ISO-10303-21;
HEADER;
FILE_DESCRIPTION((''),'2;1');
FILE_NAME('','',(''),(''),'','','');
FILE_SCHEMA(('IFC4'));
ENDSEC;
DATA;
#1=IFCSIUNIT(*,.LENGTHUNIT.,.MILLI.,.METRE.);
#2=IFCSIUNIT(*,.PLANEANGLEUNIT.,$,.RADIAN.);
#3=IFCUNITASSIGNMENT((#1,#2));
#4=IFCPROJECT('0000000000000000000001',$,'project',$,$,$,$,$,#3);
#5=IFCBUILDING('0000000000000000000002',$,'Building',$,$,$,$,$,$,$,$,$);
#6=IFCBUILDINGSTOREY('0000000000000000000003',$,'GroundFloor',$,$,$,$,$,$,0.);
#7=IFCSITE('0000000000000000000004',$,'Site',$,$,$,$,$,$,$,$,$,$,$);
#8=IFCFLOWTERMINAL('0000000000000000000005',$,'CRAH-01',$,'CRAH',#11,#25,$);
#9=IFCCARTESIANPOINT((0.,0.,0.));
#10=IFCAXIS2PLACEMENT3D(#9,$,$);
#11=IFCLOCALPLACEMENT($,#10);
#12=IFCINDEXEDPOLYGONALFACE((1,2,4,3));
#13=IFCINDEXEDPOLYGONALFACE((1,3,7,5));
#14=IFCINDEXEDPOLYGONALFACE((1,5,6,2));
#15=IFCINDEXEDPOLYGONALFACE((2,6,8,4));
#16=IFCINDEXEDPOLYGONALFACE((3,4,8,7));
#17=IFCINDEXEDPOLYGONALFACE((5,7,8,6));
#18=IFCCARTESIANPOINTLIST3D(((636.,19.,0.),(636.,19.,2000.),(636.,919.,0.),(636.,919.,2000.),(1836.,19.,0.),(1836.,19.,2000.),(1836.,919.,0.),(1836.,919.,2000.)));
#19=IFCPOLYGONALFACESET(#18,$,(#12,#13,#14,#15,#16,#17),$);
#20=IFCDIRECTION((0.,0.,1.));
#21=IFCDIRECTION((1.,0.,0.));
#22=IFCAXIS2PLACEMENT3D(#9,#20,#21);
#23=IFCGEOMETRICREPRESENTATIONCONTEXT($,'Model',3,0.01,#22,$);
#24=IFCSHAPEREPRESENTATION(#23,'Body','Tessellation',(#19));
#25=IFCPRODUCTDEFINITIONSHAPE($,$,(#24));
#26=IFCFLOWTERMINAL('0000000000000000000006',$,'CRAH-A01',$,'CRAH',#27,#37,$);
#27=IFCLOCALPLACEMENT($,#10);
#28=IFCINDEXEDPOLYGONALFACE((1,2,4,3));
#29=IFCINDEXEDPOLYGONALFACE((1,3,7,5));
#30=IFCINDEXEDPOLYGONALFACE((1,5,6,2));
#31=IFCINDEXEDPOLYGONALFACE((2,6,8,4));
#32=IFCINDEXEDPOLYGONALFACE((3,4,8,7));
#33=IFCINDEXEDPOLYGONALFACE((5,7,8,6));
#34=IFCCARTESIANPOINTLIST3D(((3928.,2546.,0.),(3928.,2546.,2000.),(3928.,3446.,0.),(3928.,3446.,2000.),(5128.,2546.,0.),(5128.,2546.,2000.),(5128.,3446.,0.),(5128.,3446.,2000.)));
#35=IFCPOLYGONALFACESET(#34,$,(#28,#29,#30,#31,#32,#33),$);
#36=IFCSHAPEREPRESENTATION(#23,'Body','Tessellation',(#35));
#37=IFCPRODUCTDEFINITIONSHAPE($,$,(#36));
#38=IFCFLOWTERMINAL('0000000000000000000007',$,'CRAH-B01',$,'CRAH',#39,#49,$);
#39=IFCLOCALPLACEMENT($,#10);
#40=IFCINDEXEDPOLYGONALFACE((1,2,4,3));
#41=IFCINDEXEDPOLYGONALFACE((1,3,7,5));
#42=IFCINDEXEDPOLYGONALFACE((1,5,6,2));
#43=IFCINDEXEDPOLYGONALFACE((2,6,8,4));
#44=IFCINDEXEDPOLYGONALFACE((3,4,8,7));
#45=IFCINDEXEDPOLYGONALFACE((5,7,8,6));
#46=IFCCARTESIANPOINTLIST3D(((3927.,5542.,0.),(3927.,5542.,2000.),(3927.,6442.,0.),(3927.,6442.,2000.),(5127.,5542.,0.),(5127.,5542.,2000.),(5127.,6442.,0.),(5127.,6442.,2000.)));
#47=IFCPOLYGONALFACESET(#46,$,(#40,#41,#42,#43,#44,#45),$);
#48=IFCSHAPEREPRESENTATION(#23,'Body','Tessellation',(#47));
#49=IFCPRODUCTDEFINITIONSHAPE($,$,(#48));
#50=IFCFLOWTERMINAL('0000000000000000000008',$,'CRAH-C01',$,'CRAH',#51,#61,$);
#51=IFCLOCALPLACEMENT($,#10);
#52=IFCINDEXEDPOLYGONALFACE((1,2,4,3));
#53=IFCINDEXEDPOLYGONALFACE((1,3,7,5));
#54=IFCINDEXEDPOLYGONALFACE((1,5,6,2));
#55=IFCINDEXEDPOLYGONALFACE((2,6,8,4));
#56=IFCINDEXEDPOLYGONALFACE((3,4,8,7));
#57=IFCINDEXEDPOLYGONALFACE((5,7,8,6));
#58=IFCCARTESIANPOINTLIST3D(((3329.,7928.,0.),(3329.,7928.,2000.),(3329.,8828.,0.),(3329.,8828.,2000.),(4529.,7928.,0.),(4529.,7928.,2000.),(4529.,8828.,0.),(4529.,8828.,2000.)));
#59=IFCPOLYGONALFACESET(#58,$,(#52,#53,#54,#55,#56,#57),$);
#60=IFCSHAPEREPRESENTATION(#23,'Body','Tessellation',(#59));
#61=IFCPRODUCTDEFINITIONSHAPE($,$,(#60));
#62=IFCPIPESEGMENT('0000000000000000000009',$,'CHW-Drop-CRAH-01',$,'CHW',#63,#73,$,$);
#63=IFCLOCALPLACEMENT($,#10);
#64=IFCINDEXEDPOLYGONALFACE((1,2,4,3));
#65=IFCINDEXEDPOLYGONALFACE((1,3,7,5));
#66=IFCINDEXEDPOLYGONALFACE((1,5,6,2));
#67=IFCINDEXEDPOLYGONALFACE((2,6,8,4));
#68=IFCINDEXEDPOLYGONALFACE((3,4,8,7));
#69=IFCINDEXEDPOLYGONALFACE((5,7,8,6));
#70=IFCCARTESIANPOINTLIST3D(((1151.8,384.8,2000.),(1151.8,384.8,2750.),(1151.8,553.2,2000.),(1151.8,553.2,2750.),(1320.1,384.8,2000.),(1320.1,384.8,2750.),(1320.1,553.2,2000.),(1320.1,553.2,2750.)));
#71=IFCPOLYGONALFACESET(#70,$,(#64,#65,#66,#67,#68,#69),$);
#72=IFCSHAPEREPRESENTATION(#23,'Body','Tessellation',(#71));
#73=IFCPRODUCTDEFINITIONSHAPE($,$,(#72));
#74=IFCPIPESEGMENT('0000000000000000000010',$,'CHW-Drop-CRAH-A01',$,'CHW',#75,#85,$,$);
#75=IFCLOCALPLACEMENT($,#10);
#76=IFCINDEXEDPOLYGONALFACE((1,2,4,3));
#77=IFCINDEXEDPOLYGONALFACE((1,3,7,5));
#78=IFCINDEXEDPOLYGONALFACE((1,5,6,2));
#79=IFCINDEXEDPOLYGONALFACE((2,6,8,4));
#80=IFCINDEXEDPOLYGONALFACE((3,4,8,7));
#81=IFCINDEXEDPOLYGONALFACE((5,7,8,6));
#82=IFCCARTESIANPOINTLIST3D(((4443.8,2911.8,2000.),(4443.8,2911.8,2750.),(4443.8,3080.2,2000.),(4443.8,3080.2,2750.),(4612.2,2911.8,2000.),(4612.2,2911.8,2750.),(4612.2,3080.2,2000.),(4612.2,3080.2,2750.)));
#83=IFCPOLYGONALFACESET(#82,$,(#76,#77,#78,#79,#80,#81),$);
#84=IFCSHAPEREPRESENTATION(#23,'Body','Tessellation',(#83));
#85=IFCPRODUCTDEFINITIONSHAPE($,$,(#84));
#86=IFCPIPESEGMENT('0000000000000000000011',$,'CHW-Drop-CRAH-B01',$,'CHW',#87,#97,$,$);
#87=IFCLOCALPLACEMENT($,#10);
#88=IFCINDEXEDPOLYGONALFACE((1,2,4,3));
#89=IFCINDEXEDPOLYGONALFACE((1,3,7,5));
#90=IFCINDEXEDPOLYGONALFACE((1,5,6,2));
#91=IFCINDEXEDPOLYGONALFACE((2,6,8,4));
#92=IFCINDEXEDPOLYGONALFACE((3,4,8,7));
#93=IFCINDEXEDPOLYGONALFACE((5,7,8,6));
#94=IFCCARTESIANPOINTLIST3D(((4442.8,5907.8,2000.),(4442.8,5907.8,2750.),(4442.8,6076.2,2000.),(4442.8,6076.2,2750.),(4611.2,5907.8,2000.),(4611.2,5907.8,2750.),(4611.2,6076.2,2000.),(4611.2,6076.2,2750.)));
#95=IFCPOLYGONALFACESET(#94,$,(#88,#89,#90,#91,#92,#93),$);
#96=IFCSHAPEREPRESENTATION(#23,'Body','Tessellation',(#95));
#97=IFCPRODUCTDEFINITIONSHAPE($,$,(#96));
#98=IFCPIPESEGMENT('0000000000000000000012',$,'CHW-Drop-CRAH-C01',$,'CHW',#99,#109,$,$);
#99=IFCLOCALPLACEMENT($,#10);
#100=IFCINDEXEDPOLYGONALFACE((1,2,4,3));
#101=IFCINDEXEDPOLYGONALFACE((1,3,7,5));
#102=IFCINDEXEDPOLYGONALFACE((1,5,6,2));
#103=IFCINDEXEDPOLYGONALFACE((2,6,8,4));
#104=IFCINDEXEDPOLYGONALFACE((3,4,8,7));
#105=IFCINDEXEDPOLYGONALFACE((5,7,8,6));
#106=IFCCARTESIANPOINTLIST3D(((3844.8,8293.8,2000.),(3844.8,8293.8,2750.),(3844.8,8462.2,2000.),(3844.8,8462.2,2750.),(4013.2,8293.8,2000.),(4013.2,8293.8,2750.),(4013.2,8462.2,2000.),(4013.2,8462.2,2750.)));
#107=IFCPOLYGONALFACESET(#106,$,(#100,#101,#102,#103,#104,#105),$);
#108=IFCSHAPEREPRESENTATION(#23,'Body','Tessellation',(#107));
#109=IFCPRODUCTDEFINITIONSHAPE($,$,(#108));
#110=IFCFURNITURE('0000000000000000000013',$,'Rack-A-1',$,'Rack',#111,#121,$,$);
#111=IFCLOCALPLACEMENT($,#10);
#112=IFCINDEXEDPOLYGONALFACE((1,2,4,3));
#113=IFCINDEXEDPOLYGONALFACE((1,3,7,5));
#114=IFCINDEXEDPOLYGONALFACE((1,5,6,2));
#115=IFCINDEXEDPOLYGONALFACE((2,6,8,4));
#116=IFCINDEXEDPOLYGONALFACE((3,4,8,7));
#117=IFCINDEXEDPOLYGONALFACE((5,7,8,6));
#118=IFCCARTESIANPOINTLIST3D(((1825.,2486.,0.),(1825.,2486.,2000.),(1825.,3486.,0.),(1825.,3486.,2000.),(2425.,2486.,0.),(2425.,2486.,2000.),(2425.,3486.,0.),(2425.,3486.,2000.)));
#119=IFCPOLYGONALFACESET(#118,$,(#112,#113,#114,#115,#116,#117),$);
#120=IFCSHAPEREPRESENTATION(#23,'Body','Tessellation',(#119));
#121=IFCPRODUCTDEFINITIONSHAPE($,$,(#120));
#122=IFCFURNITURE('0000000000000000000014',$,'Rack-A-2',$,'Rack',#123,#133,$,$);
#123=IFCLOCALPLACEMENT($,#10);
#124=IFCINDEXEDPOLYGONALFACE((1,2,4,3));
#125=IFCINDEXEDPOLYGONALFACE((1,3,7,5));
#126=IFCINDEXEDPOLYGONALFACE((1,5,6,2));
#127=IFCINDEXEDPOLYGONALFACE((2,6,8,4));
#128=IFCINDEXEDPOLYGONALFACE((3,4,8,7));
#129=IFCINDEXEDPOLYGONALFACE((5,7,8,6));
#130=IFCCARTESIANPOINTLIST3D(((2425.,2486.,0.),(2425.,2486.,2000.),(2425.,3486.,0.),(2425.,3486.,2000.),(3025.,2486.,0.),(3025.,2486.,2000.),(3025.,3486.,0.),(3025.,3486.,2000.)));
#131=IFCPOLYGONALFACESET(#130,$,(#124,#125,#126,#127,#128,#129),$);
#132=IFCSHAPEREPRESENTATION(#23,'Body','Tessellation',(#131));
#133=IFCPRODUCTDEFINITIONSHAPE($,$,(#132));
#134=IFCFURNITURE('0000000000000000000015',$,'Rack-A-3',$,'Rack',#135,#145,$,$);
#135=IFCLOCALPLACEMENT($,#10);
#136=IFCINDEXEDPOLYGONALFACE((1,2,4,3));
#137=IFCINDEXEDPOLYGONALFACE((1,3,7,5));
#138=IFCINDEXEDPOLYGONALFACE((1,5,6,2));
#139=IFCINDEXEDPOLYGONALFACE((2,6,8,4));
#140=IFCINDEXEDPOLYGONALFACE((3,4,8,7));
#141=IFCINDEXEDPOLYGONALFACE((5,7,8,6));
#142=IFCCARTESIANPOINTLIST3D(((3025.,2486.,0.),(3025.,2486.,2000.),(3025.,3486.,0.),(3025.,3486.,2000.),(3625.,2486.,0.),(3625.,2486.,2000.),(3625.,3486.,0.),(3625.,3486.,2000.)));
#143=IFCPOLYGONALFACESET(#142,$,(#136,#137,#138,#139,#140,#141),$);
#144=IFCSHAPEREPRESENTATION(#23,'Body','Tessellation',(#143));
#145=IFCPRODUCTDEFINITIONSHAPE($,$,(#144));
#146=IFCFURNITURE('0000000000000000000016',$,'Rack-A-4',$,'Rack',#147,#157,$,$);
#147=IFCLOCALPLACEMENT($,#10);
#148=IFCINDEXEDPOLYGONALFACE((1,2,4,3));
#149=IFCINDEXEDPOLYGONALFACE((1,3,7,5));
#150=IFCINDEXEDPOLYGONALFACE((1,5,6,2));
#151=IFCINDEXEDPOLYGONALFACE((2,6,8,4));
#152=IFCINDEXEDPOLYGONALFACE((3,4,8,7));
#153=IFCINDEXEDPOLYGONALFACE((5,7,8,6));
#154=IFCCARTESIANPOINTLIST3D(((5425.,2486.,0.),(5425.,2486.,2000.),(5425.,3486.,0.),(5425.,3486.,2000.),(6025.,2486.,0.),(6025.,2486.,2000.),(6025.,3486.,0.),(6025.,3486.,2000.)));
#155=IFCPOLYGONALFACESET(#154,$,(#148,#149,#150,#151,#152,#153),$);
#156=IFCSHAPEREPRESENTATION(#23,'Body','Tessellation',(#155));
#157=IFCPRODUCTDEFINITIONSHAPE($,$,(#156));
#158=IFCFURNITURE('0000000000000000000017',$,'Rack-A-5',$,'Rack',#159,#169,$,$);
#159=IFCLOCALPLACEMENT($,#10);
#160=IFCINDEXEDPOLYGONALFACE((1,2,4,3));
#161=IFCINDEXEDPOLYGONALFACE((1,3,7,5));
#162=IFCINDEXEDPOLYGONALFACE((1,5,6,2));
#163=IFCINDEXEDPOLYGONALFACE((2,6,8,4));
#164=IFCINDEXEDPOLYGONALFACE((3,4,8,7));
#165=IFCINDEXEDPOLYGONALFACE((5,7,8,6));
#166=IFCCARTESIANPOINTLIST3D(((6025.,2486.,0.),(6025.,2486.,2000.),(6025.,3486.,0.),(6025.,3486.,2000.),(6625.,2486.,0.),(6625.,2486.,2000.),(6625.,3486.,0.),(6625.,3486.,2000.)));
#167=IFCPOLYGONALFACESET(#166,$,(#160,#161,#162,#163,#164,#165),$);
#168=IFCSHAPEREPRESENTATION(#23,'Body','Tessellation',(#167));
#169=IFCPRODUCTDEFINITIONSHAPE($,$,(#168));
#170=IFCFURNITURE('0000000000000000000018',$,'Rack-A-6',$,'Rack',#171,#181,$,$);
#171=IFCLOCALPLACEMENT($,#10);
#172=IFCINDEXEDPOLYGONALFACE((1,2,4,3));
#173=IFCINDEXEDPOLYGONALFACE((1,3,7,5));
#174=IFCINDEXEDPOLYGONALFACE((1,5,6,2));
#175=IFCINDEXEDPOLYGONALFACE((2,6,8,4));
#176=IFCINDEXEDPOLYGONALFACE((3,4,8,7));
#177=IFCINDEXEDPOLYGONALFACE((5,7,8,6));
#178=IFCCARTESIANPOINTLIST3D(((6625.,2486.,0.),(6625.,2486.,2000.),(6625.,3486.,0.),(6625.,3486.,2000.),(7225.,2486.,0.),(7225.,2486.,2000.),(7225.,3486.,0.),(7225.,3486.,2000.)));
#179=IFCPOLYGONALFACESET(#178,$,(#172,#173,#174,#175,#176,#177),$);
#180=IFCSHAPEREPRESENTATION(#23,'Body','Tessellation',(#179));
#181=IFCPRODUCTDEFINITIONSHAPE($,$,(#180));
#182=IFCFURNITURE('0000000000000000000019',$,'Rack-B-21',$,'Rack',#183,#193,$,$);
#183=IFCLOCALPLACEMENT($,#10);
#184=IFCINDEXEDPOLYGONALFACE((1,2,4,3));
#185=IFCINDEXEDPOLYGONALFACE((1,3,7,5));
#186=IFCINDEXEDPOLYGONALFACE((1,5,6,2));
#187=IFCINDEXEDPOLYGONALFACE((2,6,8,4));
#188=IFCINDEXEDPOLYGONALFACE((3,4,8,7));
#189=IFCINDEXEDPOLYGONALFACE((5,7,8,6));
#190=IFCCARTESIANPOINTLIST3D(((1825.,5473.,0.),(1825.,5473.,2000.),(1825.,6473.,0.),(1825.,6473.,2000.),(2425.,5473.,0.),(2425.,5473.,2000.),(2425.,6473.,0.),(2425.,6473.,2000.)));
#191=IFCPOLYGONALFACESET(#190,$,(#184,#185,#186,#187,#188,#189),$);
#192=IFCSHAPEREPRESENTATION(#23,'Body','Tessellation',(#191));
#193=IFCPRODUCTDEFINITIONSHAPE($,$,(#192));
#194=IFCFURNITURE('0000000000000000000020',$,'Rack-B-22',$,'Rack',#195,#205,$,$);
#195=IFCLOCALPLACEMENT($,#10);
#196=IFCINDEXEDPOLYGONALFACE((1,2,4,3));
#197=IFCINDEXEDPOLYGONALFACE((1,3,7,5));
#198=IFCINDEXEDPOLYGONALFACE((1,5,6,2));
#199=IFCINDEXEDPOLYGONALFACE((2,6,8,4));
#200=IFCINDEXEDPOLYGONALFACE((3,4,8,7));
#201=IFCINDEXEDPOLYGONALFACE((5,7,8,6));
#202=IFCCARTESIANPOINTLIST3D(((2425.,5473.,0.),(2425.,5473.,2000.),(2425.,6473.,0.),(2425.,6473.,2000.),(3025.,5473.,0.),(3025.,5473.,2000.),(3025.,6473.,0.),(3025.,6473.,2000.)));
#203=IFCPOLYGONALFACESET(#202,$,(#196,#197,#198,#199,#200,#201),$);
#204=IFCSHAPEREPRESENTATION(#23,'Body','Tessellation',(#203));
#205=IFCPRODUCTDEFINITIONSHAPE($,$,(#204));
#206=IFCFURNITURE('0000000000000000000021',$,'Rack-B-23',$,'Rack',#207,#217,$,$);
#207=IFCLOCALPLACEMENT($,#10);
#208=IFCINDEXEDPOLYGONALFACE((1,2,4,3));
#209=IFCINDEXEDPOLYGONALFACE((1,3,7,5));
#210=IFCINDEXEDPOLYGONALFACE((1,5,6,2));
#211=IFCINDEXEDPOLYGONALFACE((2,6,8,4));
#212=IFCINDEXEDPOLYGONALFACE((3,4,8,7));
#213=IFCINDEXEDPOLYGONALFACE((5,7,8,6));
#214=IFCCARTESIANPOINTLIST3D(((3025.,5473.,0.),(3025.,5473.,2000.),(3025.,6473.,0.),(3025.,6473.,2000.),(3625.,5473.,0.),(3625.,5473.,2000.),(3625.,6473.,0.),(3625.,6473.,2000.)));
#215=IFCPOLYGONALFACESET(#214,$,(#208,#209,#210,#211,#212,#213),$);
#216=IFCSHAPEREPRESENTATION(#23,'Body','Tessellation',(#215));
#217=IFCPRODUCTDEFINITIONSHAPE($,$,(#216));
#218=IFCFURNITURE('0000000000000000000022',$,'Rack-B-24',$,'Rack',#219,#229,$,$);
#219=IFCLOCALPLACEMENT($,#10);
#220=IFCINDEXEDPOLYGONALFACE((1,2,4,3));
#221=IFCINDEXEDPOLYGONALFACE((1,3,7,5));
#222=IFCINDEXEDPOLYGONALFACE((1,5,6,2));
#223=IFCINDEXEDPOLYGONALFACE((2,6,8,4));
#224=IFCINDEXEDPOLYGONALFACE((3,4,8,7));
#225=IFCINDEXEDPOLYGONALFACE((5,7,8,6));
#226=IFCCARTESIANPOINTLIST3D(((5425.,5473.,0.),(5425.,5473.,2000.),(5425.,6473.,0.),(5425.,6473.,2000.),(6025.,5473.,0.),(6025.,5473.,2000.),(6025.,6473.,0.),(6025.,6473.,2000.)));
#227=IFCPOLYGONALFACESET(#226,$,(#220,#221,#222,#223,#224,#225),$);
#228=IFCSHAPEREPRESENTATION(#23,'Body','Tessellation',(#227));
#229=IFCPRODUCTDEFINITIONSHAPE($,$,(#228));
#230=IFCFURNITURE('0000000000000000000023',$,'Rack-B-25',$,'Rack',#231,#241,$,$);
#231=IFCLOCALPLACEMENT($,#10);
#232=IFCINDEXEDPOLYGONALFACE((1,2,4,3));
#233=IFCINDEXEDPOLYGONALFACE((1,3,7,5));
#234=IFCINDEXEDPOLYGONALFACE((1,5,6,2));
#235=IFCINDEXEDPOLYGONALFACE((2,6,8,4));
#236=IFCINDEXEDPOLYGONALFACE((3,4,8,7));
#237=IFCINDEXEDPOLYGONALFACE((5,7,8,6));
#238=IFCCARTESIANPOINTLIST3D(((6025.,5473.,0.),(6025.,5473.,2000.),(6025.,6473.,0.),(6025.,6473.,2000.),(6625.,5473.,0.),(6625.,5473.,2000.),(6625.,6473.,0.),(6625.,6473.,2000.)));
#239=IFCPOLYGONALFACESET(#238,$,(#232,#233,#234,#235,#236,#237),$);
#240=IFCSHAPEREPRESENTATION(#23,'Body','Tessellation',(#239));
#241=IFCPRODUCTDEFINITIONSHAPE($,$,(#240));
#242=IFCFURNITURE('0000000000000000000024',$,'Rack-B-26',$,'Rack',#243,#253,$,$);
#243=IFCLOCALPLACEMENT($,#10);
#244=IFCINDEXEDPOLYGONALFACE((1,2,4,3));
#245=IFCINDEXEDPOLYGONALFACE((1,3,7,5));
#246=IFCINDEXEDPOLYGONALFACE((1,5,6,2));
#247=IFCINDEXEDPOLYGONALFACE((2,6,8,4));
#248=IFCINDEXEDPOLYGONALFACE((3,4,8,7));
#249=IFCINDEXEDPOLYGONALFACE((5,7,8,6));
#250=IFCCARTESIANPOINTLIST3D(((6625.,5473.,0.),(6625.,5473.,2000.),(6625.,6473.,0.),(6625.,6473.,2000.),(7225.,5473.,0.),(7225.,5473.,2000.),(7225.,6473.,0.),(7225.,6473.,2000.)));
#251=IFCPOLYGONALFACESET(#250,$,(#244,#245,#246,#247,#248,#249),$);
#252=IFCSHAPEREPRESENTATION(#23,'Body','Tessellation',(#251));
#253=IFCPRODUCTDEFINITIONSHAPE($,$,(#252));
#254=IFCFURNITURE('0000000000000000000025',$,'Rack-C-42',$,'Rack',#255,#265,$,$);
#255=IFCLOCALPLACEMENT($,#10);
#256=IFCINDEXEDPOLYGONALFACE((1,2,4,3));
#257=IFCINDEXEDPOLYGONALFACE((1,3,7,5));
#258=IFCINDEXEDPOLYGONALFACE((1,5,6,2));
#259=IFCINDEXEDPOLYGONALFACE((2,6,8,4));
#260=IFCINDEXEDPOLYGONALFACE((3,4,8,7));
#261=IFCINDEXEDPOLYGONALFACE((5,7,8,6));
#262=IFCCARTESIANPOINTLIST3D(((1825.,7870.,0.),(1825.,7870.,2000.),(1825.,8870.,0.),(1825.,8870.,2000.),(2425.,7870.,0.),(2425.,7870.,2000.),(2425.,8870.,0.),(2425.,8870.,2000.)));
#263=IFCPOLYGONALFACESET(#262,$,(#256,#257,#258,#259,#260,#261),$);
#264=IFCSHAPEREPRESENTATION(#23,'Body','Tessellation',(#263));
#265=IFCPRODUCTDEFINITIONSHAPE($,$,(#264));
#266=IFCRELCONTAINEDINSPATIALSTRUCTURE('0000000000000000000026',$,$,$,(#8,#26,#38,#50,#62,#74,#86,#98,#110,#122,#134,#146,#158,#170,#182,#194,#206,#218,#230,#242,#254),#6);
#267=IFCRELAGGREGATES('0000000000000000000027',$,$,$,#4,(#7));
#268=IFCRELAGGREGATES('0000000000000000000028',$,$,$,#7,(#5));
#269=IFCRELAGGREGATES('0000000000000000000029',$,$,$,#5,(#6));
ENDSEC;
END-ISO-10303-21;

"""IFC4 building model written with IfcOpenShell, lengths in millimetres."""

from ifc_helpers import new_model, si_unit, frame, origin, origin_with_axes, origin_2d, place, context, project, spatial, rectangle, extrude, element, save


model = new_model("IFC4")

# Units and contexts
model_context = context("Model", 3, precision=0.01, world=origin_with_axes())
ifc_project = project(units=[si_unit("LENGTHUNIT", "METRE", prefix="MILLI"), si_unit("PLANEANGLEUNIT", "RADIAN")])

# Site, building, storey
site = spatial("IfcSite", under=ifc_project, Name="Site")
building = spatial("IfcBuilding", under=site, Name="Building")
storey = spatial("IfcBuildingStorey", under=building, Name="GroundFloor", Elevation=0.0)

# Flow terminals
for number, where, z_axis, x_axis, name in (
    (1, (1236.0, 469.0, 0.0), (0.0, 0.0, 1.0), (1.0, 0.0, 0.0), "CRAH-01"),
    (2, (4528.0, 2996.0, 0.0), (0.0, 0.0, 1.0), (1.0, 0.0, 0.0), "CRAH-A01"),
    (3, (4527.0, 5992.0, 0.0), (0.0, 0.0, 1.0), (1.0, 0.0, 0.0), "CRAH-B01"),
    (4, (3929.0, 8378.0, 0.0), (0.0, 0.0, 1.0), (1.0, 0.0, 0.0), "CRAH-C01"),
):
    element("IfcFlowTerminal", number, at=place(None, frame(where, z_axis=z_axis, x_axis=x_axis)), inside=storey, Name=name, ObjectType="CRAH", context=model_context, shape_type="SweptSolid", body=[
        extrude(rectangle(XDim=1200.0, YDim=900.0, at=origin_2d()), origin(), (0.0, 0.0, 1.0), 2000.0),
    ])

# Pipe segments
for number, where, z_axis, x_axis, name in (
    (5, (1236.0, 469.0, 2000.0), (0.0, 0.0, 1.0), (1.0, 0.0, 0.0), "CHW-Drop-CRAH-01"),
    (6, (4528.0, 2996.0, 2000.0), (0.0, 0.0, 1.0), (1.0, 0.0, 0.0), "CHW-Drop-CRAH-A01"),
    (7, (4527.0, 5992.0, 2000.0), (0.0, 0.0, 1.0), (1.0, 0.0, 0.0), "CHW-Drop-CRAH-B01"),
    (8, (3929.0, 8378.0, 2000.0), (0.0, 0.0, 1.0), (1.0, 0.0, 0.0), "CHW-Drop-CRAH-C01"),
):
    element("IfcPipeSegment", number, at=place(None, frame(where, z_axis=z_axis, x_axis=x_axis)), inside=storey, Name=name, ObjectType="CHW", context=model_context, shape_type="SweptSolid", body=[
        extrude(rectangle(XDim=168.3, YDim=168.3, at=origin_2d()), origin(), (0.0, 0.0, 1.0), 750.0),
    ])

# Furniture
for number, where, z_axis, x_axis, name in (
    (9, (2125.0, 2986.0, 0.0), (0.0, 0.0, 1.0), (1.0, 0.0, 0.0), "Rack-A-1"),
    (10, (2725.0, 2986.0, 0.0), (0.0, 0.0, 1.0), (1.0, 0.0, 0.0), "Rack-A-2"),
    (11, (3325.0, 2986.0, 0.0), (0.0, 0.0, 1.0), (1.0, 0.0, 0.0), "Rack-A-3"),
    (12, (5725.0, 2986.0, 0.0), (0.0, 0.0, 1.0), (1.0, 0.0, 0.0), "Rack-A-4"),
    (13, (6325.0, 2986.0, 0.0), (0.0, 0.0, 1.0), (1.0, 0.0, 0.0), "Rack-A-5"),
    (14, (6925.0, 2986.0, 0.0), (0.0, 0.0, 1.0), (1.0, 0.0, 0.0), "Rack-A-6"),
    (15, (2125.0, 5973.0, 0.0), (0.0, 0.0, 1.0), (1.0, 0.0, 0.0), "Rack-B-21"),
    (16, (2725.0, 5973.0, 0.0), (0.0, 0.0, 1.0), (1.0, 0.0, 0.0), "Rack-B-22"),
    (17, (3325.0, 5973.0, 0.0), (0.0, 0.0, 1.0), (1.0, 0.0, 0.0), "Rack-B-23"),
    (18, (5725.0, 5973.0, 0.0), (0.0, 0.0, 1.0), (1.0, 0.0, 0.0), "Rack-B-24"),
    (19, (6325.0, 5973.0, 0.0), (0.0, 0.0, 1.0), (1.0, 0.0, 0.0), "Rack-B-25"),
    (20, (6925.0, 5973.0, 0.0), (0.0, 0.0, 1.0), (1.0, 0.0, 0.0), "Rack-B-26"),
    (21, (2125.0, 8370.0, 0.0), (0.0, 0.0, 1.0), (1.0, 0.0, 0.0), "Rack-C-42"),
):
    element("IfcFurniture", number, at=place(None, frame(where, z_axis=z_axis, x_axis=x_axis)), inside=storey, Name=name, ObjectType="Rack", context=model_context, shape_type="SweptSolid", body=[
        extrude(rectangle(XDim=600.0, YDim=1000.0, at=origin_2d()), origin(), (0.0, 0.0, 1.0), 2000.0),
    ])

save(model, "model.ifc")
